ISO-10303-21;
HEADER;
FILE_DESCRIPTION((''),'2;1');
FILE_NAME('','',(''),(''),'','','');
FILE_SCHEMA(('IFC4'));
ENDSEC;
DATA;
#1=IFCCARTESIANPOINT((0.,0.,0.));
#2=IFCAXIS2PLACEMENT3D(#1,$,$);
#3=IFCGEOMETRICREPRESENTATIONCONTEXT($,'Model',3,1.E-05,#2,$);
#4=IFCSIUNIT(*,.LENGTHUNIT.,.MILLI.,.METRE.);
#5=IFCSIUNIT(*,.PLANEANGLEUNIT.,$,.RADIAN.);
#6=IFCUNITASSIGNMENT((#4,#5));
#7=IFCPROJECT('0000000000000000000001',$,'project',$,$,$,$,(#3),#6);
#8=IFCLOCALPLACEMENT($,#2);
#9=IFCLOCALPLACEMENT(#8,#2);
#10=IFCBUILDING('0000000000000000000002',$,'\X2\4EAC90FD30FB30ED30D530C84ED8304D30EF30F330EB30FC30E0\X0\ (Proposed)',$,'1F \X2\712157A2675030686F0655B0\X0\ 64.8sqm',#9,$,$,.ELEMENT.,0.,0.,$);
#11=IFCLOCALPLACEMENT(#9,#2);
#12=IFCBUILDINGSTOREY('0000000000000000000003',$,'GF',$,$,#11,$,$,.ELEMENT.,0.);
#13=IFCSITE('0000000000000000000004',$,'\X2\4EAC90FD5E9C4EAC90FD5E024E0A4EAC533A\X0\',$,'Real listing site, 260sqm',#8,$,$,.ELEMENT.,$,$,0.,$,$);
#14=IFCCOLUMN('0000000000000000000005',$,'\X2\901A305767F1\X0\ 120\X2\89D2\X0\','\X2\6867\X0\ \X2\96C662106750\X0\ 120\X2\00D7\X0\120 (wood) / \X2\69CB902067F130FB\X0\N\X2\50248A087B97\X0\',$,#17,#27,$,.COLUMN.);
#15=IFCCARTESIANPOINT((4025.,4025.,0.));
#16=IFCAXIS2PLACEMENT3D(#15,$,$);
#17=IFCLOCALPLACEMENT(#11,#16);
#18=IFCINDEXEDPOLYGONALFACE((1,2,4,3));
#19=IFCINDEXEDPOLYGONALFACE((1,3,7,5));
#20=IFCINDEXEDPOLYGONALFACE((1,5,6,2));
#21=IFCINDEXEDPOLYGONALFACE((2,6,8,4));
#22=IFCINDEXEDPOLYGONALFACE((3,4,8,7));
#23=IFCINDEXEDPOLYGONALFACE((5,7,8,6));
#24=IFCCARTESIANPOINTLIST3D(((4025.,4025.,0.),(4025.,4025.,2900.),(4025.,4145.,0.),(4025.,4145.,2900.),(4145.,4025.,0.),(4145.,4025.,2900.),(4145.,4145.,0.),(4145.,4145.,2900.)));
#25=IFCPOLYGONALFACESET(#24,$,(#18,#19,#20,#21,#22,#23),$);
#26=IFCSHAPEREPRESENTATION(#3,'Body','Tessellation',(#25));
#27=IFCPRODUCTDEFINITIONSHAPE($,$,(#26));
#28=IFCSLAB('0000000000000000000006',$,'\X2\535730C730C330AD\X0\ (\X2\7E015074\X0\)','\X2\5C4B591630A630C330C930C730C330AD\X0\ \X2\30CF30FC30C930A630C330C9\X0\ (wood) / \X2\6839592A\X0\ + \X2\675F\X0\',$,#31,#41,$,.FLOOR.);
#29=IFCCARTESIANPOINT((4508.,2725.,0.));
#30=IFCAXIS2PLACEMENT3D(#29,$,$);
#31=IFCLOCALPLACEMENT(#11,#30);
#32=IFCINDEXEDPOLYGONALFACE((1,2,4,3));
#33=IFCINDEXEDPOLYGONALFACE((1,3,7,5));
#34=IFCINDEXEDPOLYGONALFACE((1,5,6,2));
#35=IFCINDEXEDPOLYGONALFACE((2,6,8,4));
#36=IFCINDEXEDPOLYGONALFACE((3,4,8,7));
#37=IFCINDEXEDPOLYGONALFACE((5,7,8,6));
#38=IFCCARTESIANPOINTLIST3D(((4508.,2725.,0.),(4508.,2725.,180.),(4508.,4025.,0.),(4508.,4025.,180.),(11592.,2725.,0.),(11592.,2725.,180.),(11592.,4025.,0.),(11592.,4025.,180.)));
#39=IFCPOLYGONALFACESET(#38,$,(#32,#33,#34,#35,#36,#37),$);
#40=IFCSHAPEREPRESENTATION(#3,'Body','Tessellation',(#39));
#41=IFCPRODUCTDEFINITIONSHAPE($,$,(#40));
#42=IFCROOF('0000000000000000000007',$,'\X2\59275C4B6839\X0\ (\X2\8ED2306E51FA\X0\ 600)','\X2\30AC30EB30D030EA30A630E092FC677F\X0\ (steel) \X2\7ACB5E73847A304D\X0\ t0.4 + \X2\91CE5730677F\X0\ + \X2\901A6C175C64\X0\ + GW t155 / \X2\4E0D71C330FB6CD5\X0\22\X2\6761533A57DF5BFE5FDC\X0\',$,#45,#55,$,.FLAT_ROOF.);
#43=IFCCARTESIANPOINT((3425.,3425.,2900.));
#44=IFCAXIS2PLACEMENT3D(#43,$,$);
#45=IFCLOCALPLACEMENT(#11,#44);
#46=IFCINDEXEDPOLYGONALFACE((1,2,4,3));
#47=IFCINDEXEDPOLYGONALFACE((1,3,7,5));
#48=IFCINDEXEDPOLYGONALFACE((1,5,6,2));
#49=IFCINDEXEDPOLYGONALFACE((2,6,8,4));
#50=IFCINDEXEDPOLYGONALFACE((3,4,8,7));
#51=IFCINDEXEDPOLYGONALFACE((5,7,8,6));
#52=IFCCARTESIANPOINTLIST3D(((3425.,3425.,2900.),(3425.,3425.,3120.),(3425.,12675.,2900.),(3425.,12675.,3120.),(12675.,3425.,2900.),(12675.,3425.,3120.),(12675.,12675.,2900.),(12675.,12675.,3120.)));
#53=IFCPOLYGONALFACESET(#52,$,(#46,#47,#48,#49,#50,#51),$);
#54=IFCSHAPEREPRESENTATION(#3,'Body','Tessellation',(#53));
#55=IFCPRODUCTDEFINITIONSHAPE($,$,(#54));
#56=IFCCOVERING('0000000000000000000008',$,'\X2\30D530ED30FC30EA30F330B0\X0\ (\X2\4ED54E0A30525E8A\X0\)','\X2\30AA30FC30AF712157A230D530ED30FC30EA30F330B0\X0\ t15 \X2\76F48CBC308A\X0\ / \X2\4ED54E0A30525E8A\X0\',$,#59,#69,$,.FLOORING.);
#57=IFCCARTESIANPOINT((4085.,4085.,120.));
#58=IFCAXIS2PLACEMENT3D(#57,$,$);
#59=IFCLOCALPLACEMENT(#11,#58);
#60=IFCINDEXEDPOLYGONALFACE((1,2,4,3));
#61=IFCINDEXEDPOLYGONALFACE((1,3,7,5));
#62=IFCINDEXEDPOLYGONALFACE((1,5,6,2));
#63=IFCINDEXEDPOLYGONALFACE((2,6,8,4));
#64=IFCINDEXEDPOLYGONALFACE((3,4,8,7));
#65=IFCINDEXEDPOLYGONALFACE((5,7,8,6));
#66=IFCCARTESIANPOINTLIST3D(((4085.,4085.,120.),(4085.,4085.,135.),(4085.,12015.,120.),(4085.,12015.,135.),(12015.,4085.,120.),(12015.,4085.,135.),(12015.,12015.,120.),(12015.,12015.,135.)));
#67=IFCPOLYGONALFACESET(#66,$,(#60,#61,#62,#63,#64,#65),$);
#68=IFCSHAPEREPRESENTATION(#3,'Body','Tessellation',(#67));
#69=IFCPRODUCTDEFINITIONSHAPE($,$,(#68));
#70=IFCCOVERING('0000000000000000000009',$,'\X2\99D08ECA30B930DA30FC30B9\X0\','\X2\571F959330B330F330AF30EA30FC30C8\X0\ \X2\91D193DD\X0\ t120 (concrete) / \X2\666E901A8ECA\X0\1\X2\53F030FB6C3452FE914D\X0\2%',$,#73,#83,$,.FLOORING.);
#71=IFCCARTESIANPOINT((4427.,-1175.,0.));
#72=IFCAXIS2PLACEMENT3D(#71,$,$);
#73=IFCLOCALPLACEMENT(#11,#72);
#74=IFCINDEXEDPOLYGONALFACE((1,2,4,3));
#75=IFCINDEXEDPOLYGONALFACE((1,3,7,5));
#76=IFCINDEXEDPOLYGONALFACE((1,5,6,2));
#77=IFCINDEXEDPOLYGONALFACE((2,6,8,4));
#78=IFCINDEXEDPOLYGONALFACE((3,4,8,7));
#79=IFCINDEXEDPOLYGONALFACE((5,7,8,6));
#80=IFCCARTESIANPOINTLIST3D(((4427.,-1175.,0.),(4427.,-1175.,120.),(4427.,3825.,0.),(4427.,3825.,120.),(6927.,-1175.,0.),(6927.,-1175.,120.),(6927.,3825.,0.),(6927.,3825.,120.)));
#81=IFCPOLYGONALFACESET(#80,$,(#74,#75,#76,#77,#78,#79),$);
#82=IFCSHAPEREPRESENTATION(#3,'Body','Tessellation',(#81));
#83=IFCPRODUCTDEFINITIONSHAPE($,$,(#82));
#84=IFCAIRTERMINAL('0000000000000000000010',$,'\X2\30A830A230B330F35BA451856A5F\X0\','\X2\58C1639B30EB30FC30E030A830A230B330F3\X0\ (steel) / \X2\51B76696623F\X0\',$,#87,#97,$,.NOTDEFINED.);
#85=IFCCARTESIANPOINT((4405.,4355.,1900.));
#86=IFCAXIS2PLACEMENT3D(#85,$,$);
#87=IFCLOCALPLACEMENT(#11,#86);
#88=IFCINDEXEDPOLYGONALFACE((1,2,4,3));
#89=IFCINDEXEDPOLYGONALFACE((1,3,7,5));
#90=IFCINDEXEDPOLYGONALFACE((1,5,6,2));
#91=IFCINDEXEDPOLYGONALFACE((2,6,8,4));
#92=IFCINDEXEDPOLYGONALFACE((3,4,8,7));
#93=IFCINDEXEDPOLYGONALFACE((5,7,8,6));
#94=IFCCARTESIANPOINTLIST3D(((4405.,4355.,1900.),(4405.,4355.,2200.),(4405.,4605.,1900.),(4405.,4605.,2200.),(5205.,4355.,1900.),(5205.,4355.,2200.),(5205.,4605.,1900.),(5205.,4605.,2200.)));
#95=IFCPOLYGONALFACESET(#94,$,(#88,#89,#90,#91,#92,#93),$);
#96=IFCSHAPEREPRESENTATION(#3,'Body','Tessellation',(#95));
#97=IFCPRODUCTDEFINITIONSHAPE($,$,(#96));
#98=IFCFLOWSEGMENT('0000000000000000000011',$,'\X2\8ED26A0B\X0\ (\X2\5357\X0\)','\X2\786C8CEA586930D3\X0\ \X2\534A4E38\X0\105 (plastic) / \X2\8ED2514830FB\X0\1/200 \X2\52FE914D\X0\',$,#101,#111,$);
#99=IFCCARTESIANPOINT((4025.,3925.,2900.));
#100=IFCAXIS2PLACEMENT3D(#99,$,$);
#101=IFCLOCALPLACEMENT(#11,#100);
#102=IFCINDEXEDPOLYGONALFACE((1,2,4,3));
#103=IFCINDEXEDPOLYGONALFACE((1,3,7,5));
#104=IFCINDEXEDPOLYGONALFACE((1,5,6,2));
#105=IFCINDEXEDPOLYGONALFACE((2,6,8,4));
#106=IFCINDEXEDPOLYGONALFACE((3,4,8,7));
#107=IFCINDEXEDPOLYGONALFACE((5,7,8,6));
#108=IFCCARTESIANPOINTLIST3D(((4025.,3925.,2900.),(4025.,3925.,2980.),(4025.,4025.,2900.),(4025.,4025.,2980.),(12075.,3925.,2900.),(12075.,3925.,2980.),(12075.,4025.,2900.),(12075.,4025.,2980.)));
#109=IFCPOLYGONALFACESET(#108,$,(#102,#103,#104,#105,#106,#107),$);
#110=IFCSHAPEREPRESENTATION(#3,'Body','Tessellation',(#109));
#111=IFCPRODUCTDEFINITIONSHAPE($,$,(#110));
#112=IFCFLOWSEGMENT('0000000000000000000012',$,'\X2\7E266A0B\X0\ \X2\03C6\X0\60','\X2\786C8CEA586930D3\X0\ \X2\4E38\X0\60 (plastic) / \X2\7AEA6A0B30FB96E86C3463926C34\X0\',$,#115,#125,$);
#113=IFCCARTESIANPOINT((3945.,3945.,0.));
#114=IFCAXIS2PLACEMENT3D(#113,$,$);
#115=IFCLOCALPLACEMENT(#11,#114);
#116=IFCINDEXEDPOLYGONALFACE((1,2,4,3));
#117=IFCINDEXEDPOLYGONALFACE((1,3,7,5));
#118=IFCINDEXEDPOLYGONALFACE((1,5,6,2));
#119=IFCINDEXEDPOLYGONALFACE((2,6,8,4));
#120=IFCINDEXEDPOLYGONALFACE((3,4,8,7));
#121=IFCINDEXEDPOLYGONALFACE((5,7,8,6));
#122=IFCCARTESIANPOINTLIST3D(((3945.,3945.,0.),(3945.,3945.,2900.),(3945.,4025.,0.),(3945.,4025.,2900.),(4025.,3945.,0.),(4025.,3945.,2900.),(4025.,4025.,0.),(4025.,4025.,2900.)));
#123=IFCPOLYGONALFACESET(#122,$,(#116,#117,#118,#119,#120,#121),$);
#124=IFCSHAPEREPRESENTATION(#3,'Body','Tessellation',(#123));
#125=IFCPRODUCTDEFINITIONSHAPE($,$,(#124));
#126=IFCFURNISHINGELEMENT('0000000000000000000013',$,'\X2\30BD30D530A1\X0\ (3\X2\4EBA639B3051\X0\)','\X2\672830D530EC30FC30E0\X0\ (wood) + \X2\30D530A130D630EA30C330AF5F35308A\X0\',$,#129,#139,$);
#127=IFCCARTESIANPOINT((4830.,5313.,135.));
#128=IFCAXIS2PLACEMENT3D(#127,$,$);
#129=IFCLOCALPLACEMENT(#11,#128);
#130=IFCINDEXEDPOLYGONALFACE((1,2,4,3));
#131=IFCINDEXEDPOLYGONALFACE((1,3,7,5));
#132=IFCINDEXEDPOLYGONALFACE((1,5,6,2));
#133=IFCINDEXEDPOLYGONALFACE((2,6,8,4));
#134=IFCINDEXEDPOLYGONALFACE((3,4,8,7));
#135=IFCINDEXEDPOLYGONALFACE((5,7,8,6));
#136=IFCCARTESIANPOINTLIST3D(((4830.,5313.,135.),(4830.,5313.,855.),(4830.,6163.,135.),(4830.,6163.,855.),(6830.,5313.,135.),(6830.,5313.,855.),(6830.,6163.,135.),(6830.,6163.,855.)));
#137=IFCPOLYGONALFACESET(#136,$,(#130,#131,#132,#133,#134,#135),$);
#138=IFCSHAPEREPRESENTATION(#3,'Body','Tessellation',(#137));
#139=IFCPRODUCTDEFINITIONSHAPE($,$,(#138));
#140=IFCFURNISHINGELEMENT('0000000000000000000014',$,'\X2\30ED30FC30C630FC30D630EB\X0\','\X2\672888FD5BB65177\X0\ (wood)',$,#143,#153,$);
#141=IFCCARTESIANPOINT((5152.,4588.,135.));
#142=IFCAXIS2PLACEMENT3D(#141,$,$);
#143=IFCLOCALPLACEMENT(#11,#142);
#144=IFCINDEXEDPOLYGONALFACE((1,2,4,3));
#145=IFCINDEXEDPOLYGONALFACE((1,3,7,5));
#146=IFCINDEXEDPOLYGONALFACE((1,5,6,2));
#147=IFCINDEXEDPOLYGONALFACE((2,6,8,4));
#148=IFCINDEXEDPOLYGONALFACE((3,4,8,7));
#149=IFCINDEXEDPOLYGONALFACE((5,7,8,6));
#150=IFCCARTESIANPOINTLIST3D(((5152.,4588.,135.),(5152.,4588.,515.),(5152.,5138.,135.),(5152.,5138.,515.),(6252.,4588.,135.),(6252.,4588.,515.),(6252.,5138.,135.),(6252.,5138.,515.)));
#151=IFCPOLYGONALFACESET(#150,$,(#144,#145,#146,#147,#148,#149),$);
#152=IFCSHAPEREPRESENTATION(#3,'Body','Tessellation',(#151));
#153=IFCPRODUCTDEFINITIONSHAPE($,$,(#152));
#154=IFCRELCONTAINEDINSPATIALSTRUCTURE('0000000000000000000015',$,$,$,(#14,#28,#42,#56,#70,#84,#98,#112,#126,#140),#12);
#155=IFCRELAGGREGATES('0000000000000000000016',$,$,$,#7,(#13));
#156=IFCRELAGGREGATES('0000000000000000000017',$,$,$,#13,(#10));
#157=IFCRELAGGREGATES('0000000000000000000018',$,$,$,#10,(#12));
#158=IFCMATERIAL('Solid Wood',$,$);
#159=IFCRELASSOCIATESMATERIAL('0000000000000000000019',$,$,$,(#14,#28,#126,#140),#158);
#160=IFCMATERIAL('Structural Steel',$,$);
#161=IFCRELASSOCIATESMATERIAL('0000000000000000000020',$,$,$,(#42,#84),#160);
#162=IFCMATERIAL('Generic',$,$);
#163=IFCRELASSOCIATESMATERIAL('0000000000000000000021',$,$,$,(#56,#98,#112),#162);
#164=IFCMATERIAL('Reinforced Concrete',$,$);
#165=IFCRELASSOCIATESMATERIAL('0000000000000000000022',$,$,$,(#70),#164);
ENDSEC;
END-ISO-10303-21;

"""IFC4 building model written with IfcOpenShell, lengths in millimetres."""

from ifc_helpers import new_model, si_unit, frame, frame_2d, origin, place, context, project, spatial, rectangle, extrude, material, element, save


model = new_model("IFC4")

# Units and contexts
model_context = context("Model", 3, precision=1e-05, world=origin())
ifc_project = project(units=[si_unit("LENGTHUNIT", "METRE", prefix="MILLI"), si_unit("PLANEANGLEUNIT", "RADIAN")], contexts=[model_context])

# Site, building, storey
site_placement = place(None, origin())
site = spatial("IfcSite", under=ifc_project, at=site_placement, Name="京都府京都市上京区", ObjectType="Real listing site, 260sqm", CompositionType="ELEMENT", RefElevation=0.0)
building_placement = place(site_placement, origin())
building = spatial("IfcBuilding", under=site, at=building_placement, Name="京都・ロフト付きワンルーム (Proposed)", ObjectType="1F 無垢材と漆喰 64.8sqm", CompositionType="ELEMENT", ElevationOfRefHeight=0.0, ElevationOfTerrain=0.0)
storey_placement = place(building_placement, origin())
storey = spatial("IfcBuildingStorey", under=building, at=storey_placement, Name="GF", CompositionType="ELEMENT", Elevation=0.0)

# Column
ifc_material_1 = material(Name="Solid Wood")
column_1_placement = place(storey_placement, frame((4025.0, 4025.0, 0.0)))
element("IfcColumn", 1, at=column_1_placement, inside=storey, material=ifc_material_1, Name="通し柱 120角", Description="桧 集成材 120×120 (wood) / 構造柱・N値計算", PredefinedType="COLUMN", context=model_context, shape_type="SweptSolid", body=[
    extrude(rectangle(XDim=120.0, YDim=120.0, at=frame_2d((60.0, 60.0))), frame((4025.0, 4025.0, 0.0)), (0.0, 0.0, 1.0), 2900.0),
])

# Slab
ifc_material_2 = material(Name="Reinforced Concrete")
slab_1_placement = place(storey_placement, frame((4508.0, 2725.0, 0.0)))
element("IfcSlab", 2, at=slab_1_placement, inside=storey, material=ifc_material_1, Name="南デッキ (縁側)", Description="屋外ウッドデッキ ハードウッド (wood) / 根太 + 束", PredefinedType="FLOOR", context=model_context, shape_type="SweptSolid", body=[
    extrude(rectangle(XDim=7084.0, YDim=1300.0, at=frame_2d((3542.0, 650.0))), frame((4508.0, 2725.0, 0.0)), (0.0, 0.0, 1.0), 180.0),
])

# Roof
ifc_material_3 = material(Name="Structural Steel")
roof_placement = place(storey_placement, frame((3425.0, 3425.0, 2900.0)))
element("IfcRoof", 3, at=roof_placement, inside=storey, material=ifc_material_3, Name="大屋根 (軒の出 600)", Description="ガルバリウム鋼板 (steel) 立平葺き t0.4 + 野地板 + 通気層 + GW t155 / 不燃・法22条区域対応", PredefinedType="FLAT_ROOF", context=model_context, shape_type="SweptSolid", body=[
    extrude(rectangle(XDim=9250.0, YDim=9250.0, at=frame_2d((4625.0, 4625.0))), frame((3425.0, 3425.0, 2900.0)), (0.0, 0.0, 1.0), 220.0),
])

# Coverings
ifc_material_4 = material(Name="Generic")
covering_1_placement = place(storey_placement, frame((4085.0, 4085.0, 120.0)))
element("IfcCovering", 4, at=covering_1_placement, inside=storey, material=ifc_material_4, Name="フローリング (仕上げ床)", Description="オーク無垢フローリング t15 直貼り / 仕上げ床", PredefinedType="FLOORING", context=model_context, shape_type="SweptSolid", body=[
    extrude(rectangle(XDim=7930.0, YDim=7930.0, at=frame_2d((3965.0, 3965.0))), frame((4085.0, 4085.0, 120.0)), (0.0, 0.0, 1.0), 15.0),
])
covering_2_placement = place(storey_placement, frame((4427.0, -1175.0, 0.0)))
element("IfcCovering", 5, at=covering_2_placement, inside=storey, material=ifc_material_2, Name="駐車スペース", Description="土間コンクリート 金鏝 t120 (concrete) / 普通車1台・水勾配2%", PredefinedType="FLOORING", context=model_context, shape_type="SweptSolid", body=[
    extrude(rectangle(XDim=2500.0, YDim=5000.0, at=frame_2d((1250.0, 2500.0))), frame((4427.0, -1175.0, 0.0)), (0.0, 0.0, 1.0), 120.0),
])

# Air terminal
air_terminal_placement = place(storey_placement, frame((4405.0, 4355.0, 1900.0)))
element("IfcAirTerminal", 6, at=air_terminal_placement, inside=storey, material=ifc_material_3, Name="エアコン室内機", Description="壁掛ルームエアコン (steel) / 冷暖房", PredefinedType="NOTDEFINED", context=model_context, shape_type="SweptSolid", body=[
    extrude(rectangle(XDim=800.0, YDim=250.0, at=frame_2d((400.0, 125.0))), frame((4405.0, 4355.0, 1900.0)), (0.0, 0.0, 1.0), 300.0),
])

# Flow segments
flow_segment_1_placement = place(storey_placement, frame((4025.0, 3925.0, 2900.0)))
element("IfcFlowSegment", 7, at=flow_segment_1_placement, inside=storey, material=ifc_material_4, Name="軒樋 (南)", Description="硬質塩ビ 半丸105 (plastic) / 軒先・1/200 勾配", context=model_context, shape_type="SweptSolid", body=[
    extrude(rectangle(XDim=8050.0, YDim=100.0, at=frame_2d((4025.0, 50.0))), frame((4025.0, 3925.0, 2900.0)), (0.0, 0.0, 1.0), 80.0),
])
flow_segment_2_placement = place(storey_placement, frame((3945.0, 3945.0, 0.0)))
element("IfcFlowSegment", 8, at=flow_segment_2_placement, inside=storey, material=ifc_material_4, Name="縦樋 φ60", Description="硬質塩ビ 丸60 (plastic) / 竪樋・雨水排水", context=model_context, shape_type="SweptSolid", body=[
    extrude(rectangle(XDim=80.0, YDim=80.0, at=frame_2d((40.0, 40.0))), frame((3945.0, 3945.0, 0.0)), (0.0, 0.0, 1.0), 2900.0),
])

# Furnishing elements
furnishing_1_placement = place(storey_placement, frame((4830.0, 5313.0, 135.0)))
element("IfcFurnishingElement", 9, at=furnishing_1_placement, inside=storey, material=ifc_material_1, Name="ソファ (3人掛け)", Description="木フレーム (wood) + ファブリック張り", context=model_context, shape_type="SweptSolid", body=[
    extrude(rectangle(XDim=2000.0, YDim=850.0, at=frame_2d((1000.0, 425.0))), frame((4830.0, 5313.0, 135.0)), (0.0, 0.0, 1.0), 720.0),
])
furnishing_2_placement = place(storey_placement, frame((5152.0, 4588.0, 135.0)))
element("IfcFurnishingElement", 10, at=furnishing_2_placement, inside=storey, material=ifc_material_1, Name="ローテーブル", Description="木製家具 (wood)", context=model_context, shape_type="SweptSolid", body=[
    extrude(rectangle(XDim=1100.0, YDim=550.0, at=frame_2d((550.0, 275.0))), frame((5152.0, 4588.0, 135.0)), (0.0, 0.0, 1.0), 380.0),
])

save(model, "model.ifc")
